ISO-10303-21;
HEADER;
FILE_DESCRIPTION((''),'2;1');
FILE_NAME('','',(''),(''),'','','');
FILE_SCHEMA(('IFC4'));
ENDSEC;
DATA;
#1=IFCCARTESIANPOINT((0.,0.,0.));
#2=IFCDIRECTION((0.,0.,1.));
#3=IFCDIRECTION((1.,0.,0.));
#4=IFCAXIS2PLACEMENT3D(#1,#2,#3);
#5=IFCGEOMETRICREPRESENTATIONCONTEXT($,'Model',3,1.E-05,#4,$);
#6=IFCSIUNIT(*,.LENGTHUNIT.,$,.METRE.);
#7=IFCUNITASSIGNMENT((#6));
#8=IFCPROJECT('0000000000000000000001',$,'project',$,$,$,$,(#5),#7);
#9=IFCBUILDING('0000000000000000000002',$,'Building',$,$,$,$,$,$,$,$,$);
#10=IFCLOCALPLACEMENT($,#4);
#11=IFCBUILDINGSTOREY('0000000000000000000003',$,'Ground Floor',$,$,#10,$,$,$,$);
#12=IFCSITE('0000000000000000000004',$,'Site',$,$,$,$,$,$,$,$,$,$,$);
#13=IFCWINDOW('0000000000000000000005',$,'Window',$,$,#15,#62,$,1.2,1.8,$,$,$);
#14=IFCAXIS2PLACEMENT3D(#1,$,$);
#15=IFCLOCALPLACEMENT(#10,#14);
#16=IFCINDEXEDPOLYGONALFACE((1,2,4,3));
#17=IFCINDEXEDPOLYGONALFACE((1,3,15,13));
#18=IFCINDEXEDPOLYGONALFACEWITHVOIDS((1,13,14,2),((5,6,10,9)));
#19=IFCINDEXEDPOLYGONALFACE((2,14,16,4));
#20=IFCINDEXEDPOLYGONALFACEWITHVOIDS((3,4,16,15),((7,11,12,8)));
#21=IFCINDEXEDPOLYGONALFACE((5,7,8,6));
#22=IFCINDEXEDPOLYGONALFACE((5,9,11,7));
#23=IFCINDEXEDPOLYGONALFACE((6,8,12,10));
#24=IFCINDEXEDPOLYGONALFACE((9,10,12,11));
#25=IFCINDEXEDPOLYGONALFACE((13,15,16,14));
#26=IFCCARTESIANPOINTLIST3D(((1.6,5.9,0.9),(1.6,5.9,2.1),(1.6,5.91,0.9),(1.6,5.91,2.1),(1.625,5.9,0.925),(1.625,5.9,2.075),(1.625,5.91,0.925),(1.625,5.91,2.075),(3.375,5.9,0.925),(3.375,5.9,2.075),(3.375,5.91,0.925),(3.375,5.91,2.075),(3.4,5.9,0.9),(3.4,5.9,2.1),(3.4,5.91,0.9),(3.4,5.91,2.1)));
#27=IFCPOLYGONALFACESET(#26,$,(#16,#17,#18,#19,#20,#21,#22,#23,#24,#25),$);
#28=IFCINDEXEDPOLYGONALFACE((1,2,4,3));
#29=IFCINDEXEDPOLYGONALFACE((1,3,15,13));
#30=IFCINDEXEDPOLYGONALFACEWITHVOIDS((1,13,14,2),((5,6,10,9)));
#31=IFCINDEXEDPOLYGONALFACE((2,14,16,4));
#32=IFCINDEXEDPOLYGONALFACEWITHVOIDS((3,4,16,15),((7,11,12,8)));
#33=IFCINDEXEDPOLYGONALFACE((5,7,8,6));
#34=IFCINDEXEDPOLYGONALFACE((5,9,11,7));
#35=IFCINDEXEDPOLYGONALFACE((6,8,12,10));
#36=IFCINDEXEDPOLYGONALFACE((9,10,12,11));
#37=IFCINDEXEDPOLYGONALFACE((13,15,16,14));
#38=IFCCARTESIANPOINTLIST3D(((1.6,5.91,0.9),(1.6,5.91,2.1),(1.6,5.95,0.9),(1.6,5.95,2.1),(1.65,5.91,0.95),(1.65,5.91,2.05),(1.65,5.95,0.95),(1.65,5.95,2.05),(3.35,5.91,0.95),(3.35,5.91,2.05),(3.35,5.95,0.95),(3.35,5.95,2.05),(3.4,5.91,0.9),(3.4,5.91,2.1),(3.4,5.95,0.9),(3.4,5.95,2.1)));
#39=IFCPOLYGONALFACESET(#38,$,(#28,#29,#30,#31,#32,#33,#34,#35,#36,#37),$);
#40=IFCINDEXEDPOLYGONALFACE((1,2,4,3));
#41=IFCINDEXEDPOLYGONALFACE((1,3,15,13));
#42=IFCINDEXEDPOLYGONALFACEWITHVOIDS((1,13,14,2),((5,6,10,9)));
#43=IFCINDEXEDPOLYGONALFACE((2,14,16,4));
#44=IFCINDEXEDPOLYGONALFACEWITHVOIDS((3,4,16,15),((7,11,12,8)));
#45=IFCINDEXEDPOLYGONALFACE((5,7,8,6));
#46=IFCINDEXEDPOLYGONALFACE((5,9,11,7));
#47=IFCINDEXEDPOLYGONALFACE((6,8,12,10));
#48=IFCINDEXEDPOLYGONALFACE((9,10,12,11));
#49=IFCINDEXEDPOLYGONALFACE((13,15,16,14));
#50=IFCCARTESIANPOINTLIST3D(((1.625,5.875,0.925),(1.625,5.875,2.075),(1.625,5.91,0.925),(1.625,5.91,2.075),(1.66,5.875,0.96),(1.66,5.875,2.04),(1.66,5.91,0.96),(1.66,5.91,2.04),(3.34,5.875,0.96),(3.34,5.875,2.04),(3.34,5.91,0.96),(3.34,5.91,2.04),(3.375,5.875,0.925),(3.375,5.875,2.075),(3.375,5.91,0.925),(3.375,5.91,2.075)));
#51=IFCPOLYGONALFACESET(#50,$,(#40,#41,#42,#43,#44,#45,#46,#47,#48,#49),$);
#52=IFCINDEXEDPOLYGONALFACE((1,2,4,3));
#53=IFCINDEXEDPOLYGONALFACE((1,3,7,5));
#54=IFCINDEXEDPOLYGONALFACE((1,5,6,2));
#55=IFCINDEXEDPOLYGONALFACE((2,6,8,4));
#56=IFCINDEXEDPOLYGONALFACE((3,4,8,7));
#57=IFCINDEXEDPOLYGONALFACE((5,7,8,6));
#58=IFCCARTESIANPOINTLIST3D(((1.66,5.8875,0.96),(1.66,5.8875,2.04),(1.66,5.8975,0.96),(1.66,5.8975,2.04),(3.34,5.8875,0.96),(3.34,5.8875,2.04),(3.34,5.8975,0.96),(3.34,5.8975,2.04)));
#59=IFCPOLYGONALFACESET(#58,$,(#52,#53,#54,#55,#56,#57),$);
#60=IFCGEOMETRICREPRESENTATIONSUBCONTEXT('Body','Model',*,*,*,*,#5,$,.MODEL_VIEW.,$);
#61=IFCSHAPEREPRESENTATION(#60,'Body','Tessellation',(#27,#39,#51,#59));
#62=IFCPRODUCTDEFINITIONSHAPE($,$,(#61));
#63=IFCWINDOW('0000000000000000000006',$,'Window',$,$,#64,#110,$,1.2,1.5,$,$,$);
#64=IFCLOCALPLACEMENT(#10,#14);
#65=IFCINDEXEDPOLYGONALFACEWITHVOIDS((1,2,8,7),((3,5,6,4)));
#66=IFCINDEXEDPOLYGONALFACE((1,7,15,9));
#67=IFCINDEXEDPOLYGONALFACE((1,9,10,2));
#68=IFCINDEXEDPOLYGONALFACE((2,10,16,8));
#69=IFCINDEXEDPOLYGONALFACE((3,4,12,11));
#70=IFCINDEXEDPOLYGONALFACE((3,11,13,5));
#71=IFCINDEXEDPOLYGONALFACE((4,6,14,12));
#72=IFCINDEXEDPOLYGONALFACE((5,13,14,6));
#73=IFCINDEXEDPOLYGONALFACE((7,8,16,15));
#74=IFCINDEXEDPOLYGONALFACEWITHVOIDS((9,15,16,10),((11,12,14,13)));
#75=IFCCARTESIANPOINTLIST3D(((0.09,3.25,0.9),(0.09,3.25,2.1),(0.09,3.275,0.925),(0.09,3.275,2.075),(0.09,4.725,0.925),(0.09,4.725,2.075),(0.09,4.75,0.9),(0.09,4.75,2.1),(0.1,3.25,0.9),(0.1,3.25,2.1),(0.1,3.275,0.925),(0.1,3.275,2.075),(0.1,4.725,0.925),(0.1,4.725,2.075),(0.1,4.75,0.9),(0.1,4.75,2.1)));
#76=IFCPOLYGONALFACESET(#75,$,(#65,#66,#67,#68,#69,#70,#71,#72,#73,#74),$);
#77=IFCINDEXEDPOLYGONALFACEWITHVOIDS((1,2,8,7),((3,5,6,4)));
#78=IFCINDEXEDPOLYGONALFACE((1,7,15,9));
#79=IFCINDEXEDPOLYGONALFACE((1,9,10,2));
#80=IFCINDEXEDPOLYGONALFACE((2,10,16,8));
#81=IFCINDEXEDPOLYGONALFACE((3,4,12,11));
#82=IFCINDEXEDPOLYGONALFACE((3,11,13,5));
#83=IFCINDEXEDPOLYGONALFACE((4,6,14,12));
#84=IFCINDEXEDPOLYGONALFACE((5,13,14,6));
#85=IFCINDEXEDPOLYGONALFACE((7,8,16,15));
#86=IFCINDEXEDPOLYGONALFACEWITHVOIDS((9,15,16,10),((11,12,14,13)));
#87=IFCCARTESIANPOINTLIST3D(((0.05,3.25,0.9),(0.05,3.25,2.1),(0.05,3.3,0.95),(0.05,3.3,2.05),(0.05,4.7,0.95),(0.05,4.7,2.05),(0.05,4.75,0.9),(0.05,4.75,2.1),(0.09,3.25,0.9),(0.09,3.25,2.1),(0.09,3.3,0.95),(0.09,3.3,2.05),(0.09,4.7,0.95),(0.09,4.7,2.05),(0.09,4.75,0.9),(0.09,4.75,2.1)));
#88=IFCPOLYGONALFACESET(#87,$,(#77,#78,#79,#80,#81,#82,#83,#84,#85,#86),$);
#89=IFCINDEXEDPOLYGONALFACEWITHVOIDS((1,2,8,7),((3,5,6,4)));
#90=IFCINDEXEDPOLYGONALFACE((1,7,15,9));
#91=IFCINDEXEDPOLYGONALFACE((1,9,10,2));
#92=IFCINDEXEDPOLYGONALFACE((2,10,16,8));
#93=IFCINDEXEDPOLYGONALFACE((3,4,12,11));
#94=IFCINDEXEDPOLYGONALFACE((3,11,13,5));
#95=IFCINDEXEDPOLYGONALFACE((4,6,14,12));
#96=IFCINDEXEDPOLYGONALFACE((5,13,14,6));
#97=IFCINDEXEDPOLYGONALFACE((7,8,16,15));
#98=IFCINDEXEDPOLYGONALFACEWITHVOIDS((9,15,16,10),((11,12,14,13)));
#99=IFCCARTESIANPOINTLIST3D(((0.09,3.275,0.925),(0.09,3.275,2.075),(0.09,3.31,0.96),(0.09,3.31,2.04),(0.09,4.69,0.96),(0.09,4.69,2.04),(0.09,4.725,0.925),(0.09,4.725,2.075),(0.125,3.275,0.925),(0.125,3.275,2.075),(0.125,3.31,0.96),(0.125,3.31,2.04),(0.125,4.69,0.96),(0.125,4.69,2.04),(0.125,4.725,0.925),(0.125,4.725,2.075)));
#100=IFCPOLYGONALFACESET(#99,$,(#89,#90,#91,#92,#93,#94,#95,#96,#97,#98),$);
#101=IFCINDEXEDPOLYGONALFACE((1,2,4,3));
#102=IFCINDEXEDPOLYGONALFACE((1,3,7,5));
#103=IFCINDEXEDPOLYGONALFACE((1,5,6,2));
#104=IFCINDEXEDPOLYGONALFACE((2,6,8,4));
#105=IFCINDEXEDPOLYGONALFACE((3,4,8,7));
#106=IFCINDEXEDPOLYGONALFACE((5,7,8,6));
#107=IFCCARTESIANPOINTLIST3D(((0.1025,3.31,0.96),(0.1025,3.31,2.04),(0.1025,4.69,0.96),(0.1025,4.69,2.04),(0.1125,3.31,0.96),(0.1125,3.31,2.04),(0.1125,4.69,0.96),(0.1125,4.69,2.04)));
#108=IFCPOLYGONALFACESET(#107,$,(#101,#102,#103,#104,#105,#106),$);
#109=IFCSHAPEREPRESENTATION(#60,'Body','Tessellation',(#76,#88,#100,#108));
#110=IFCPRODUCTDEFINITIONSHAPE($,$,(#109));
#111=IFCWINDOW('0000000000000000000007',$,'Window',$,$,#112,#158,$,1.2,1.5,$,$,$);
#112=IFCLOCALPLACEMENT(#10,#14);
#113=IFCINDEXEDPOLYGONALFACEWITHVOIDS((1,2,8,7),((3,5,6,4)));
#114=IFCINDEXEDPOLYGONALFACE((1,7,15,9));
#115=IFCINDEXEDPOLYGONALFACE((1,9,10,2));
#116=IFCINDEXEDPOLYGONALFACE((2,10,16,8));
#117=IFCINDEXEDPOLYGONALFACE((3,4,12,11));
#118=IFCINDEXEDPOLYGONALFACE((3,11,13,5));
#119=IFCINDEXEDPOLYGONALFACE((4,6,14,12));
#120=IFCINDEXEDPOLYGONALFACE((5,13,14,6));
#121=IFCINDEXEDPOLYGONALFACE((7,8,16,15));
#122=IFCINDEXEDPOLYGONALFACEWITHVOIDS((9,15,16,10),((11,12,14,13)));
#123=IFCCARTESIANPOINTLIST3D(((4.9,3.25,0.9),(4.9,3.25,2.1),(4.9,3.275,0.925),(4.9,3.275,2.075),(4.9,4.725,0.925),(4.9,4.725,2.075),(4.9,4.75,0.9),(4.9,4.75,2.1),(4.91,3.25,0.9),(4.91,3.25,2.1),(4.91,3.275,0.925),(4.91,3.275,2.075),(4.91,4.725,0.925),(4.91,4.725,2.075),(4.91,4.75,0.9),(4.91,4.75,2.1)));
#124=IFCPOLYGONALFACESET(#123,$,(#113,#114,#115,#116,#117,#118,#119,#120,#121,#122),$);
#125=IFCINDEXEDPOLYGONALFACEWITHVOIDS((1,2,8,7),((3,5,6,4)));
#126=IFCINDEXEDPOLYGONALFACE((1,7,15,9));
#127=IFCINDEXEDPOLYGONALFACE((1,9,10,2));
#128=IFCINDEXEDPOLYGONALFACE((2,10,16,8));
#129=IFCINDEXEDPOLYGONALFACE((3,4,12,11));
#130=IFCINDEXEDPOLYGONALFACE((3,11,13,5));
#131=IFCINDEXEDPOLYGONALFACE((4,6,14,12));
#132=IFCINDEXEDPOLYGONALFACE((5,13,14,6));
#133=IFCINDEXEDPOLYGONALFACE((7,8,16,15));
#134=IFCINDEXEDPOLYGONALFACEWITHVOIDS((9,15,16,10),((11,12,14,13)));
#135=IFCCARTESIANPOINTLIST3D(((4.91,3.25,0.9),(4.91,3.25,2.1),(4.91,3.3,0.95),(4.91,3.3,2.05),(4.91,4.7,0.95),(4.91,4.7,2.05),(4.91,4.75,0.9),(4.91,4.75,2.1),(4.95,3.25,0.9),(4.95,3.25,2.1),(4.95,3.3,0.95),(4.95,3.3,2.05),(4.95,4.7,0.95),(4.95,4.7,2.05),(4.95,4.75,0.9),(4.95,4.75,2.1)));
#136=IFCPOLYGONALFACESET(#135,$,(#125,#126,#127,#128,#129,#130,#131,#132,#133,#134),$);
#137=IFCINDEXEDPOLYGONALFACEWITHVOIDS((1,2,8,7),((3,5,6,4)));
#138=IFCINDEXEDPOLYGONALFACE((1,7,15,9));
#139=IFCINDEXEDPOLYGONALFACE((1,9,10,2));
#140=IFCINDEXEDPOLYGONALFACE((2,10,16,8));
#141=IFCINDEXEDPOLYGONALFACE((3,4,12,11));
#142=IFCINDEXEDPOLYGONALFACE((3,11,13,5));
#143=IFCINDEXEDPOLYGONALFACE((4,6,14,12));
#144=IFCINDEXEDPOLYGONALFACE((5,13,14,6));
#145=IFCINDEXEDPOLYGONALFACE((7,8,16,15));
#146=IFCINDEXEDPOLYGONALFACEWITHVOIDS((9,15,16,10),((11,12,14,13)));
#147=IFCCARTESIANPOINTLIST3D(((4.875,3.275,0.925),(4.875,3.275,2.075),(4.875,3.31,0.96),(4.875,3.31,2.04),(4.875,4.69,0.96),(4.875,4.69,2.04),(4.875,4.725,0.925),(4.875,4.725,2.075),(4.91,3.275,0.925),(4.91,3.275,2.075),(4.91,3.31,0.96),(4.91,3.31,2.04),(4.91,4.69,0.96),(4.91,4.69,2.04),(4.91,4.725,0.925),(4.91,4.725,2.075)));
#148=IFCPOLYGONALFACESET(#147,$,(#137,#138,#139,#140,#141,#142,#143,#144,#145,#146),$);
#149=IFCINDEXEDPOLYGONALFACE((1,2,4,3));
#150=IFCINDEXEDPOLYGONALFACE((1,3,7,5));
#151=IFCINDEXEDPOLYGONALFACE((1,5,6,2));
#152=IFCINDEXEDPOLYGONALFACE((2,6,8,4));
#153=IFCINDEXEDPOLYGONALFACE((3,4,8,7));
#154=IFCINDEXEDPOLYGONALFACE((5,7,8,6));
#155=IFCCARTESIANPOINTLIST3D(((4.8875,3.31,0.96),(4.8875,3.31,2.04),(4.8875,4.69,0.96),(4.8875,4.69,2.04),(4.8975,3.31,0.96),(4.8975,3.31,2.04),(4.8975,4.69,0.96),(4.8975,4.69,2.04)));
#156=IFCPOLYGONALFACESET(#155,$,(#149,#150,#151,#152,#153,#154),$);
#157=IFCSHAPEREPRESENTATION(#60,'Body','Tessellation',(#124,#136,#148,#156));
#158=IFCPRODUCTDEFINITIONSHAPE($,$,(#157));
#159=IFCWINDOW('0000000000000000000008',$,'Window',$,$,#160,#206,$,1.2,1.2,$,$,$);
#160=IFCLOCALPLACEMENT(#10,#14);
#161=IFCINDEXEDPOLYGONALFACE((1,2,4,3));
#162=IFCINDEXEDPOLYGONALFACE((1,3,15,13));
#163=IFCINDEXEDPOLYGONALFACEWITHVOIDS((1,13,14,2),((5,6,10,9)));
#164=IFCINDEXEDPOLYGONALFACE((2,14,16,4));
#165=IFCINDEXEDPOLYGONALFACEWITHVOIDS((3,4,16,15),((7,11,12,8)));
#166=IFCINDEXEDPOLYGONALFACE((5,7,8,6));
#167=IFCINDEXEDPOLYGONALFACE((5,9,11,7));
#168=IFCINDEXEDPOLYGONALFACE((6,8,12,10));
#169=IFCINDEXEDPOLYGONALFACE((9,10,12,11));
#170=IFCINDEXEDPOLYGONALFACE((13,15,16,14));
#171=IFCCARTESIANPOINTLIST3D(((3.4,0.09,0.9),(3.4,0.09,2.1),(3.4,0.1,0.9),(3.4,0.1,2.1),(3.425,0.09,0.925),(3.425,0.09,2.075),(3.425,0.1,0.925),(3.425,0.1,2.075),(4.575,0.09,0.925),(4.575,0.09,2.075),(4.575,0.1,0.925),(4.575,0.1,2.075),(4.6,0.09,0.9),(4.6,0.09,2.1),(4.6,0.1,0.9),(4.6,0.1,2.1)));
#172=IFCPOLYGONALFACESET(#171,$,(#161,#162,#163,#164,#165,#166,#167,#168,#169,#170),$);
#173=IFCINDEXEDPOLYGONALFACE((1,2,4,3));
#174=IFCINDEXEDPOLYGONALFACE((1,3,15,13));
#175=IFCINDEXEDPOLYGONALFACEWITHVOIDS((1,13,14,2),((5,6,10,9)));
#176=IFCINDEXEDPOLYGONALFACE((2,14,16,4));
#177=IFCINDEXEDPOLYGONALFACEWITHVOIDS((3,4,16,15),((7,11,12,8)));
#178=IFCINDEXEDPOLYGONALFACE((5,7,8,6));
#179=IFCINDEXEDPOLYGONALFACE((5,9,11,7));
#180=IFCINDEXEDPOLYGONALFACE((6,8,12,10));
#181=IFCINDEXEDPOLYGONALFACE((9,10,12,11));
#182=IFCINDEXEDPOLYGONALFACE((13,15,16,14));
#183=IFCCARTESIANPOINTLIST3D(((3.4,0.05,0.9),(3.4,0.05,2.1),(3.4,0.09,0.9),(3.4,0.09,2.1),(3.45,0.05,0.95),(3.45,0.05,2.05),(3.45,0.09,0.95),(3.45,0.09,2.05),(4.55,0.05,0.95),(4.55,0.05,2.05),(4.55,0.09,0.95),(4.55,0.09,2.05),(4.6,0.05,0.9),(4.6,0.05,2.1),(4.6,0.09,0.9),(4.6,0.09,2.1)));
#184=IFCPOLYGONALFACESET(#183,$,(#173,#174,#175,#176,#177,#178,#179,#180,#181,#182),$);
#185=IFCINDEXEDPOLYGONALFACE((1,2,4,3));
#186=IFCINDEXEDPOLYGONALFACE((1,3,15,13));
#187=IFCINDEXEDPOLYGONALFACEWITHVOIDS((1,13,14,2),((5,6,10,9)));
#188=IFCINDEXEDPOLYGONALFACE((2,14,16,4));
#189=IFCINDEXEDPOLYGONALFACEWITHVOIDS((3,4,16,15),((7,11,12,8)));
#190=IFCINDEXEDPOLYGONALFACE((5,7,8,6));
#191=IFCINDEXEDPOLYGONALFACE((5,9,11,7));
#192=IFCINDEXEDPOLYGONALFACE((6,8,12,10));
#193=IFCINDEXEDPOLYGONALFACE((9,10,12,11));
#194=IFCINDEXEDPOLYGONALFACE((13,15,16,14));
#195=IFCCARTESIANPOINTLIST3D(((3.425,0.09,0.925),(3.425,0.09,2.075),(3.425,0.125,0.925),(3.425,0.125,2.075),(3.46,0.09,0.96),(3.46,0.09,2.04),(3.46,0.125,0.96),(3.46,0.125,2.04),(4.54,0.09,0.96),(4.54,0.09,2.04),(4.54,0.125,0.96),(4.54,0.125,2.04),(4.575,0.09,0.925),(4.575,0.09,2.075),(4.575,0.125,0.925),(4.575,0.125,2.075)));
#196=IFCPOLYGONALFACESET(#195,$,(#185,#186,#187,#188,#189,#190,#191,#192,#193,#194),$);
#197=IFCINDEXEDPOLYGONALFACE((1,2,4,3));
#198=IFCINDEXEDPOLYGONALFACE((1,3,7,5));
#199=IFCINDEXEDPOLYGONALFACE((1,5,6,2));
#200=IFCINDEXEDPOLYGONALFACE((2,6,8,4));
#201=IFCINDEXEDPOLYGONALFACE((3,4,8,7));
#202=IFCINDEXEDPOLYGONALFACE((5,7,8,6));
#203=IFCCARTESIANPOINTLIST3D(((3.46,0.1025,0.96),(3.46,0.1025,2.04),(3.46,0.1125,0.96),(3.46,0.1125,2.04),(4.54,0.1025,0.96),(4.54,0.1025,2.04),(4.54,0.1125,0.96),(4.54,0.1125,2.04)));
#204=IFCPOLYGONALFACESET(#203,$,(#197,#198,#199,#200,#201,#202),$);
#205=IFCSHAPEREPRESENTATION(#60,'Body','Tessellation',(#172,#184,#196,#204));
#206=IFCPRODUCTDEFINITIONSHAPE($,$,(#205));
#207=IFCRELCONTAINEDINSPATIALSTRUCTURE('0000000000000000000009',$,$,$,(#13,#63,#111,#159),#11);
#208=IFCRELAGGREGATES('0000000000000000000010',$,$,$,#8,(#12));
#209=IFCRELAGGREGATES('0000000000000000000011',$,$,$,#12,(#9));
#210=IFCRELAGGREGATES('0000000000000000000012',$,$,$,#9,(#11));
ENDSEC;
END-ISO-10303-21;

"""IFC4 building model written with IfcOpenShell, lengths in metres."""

from ifc_helpers import new_model, si_unit, frame, origin_with_axes, place, context, subcontext, project, spatial, line, indexed_curve, outline, extrude, element, save


model = new_model("IFC4")

# Units and contexts
model_context = context("Model", 3, precision=1e-05, world=origin_with_axes())
body_context = subcontext(model_context, "Body", "Model", "MODEL_VIEW")
ifc_project = project(units=[si_unit("LENGTHUNIT", "METRE")], contexts=[model_context])

# Site, building, storey
site = spatial("IfcSite", under=ifc_project, Name="Site")
building = spatial("IfcBuilding", under=site, Name="Building")
storey_placement = place(None, origin_with_axes())
storey = spatial("IfcBuildingStorey", under=building, at=storey_placement, Name="Ground Floor")

# Windows
window_1_placement = place(storey_placement, frame((3.4, 6.0, 0.9), z_axis=(0.0, 0.0, 1.0), x_axis=(-1.0, 0.0, 0.0)))
element("IfcWindow", 1, at=window_1_placement, inside=storey, Name="Window", OverallHeight=1.2, OverallWidth=1.8, context=body_context, shape_type="SweptSolid", body=[
    extrude(outline(indexed_curve([(0.0, 0.0), (1.8, 0.0), (1.8, 1.2), (0.0, 1.2)], segments=[line(1, 2, 3, 4, 1)]), holes=[indexed_curve([(0.025, 0.025), (1.775, 0.025), (1.775, 1.175), (0.025, 1.175)], segments=[line(1, 2, 3, 4, 1)])]), frame((0.0, 0.09, 0.0), z_axis=(0.0, -1.0, 0.0), x_axis=(1.0, 0.0, 0.0)), (0.0, 0.0, -1.0), 0.01),
    extrude(outline(indexed_curve([(0.0, 0.0), (1.8, 0.0), (1.8, 1.2), (0.0, 1.2)], segments=[line(1, 2, 3, 4, 1)]), holes=[indexed_curve([(0.05, 0.05), (1.75, 0.05), (1.75, 1.15), (0.05, 1.15)], segments=[line(1, 2, 3, 4, 1)])]), frame((0.0, 0.05, 0.0), z_axis=(0.0, -1.0, 0.0), x_axis=(1.0, 0.0, 0.0)), (0.0, 0.0, -1.0), 0.04),
    extrude(outline(indexed_curve([(0.0, 0.0), (1.75, 0.0), (1.75, 1.15), (0.0, 1.15)], segments=[line(1, 2, 3, 4, 1)]), holes=[indexed_curve([(0.035, 0.035), (1.715, 0.035), (1.715, 1.115), (0.035, 1.115)], segments=[line(1, 2, 3, 4, 1)])]), frame((0.025, 0.09, 0.025), z_axis=(0.0, -1.0, 0.0), x_axis=(1.0, 0.0, 0.0)), (0.0, 0.0, -1.0), 0.035),
    extrude(outline(indexed_curve([(0.035, 0.035), (1.715, 0.035), (1.715, 1.115), (0.035, 1.115)], segments=[line(1, 2, 3, 4, 1)])), frame((0.025, 0.1025, 0.025), z_axis=(0.0, -1.0, 0.0), x_axis=(1.0, 0.0, 0.0)), (0.0, 0.0, -1.0), 0.01),
])
for number, where, z_axis, x_axis, name in (
    (2, (0.0, 4.75, 0.9), (0.0, 0.0, 1.0), (0.0, -1.0, 0.0), "Window"),
    (3, (5.0, 3.25, 0.9), (0.0, 0.0, 1.0), (0.0, 1.0, 0.0), "Window"),
):
    element("IfcWindow", number, at=place(storey_placement, frame(where, z_axis=z_axis, x_axis=x_axis)), inside=storey, Name=name, OverallHeight=1.2, OverallWidth=1.5, context=body_context, shape_type="SweptSolid", body=[
        extrude(outline(indexed_curve([(0.0, 0.0), (1.5, 0.0), (1.5, 1.2), (0.0, 1.2)], segments=[line(1, 2, 3, 4, 1)]), holes=[indexed_curve([(0.025, 0.025), (1.475, 0.025), (1.475, 1.175), (0.025, 1.175)], segments=[line(1, 2, 3, 4, 1)])]), frame((0.0, 0.09, 0.0), z_axis=(0.0, -1.0, 0.0), x_axis=(1.0, 0.0, 0.0)), (0.0, 0.0, -1.0), 0.01),
        extrude(outline(indexed_curve([(0.0, 0.0), (1.5, 0.0), (1.5, 1.2), (0.0, 1.2)], segments=[line(1, 2, 3, 4, 1)]), holes=[indexed_curve([(0.05, 0.05), (1.45, 0.05), (1.45, 1.15), (0.05, 1.15)], segments=[line(1, 2, 3, 4, 1)])]), frame((0.0, 0.05, 0.0), z_axis=(0.0, -1.0, 0.0), x_axis=(1.0, 0.0, 0.0)), (0.0, 0.0, -1.0), 0.04),
        extrude(outline(indexed_curve([(0.0, 0.0), (1.45, 0.0), (1.45, 1.15), (0.0, 1.15)], segments=[line(1, 2, 3, 4, 1)]), holes=[indexed_curve([(0.035, 0.035), (1.415, 0.035), (1.415, 1.115), (0.035, 1.115)], segments=[line(1, 2, 3, 4, 1)])]), frame((0.025, 0.09, 0.025), z_axis=(0.0, -1.0, 0.0), x_axis=(1.0, 0.0, 0.0)), (0.0, 0.0, -1.0), 0.035),
        extrude(outline(indexed_curve([(0.035, 0.035), (1.415, 0.035), (1.415, 1.115), (0.035, 1.115)], segments=[line(1, 2, 3, 4, 1)])), frame((0.025, 0.1025, 0.025), z_axis=(0.0, -1.0, 0.0), x_axis=(1.0, 0.0, 0.0)), (0.0, 0.0, -1.0), 0.01),
    ])
window_2_placement = place(storey_placement, frame((3.4, 0.0, 0.9), z_axis=(0.0, 0.0, 1.0), x_axis=(1.0, 0.0, 0.0)))
element("IfcWindow", 4, at=window_2_placement, inside=storey, Name="Window", OverallHeight=1.2, OverallWidth=1.2, context=body_context, shape_type="SweptSolid", body=[
    extrude(outline(indexed_curve([(0.0, 0.0), (1.2, 0.0), (1.2, 1.2), (0.0, 1.2)], segments=[line(1, 2, 3, 4, 1)]), holes=[indexed_curve([(0.025, 0.025), (1.175, 0.025), (1.175, 1.175), (0.025, 1.175)], segments=[line(1, 2, 3, 4, 1)])]), frame((0.0, 0.09, 0.0), z_axis=(0.0, -1.0, 0.0), x_axis=(1.0, 0.0, 0.0)), (0.0, 0.0, -1.0), 0.01),
    extrude(outline(indexed_curve([(0.0, 0.0), (1.2, 0.0), (1.2, 1.2), (0.0, 1.2)], segments=[line(1, 2, 3, 4, 1)]), holes=[indexed_curve([(0.05, 0.05), (1.15, 0.05), (1.15, 1.15), (0.05, 1.15)], segments=[line(1, 2, 3, 4, 1)])]), frame((0.0, 0.05, 0.0), z_axis=(0.0, -1.0, 0.0), x_axis=(1.0, 0.0, 0.0)), (0.0, 0.0, -1.0), 0.04),
    extrude(outline(indexed_curve([(0.0, 0.0), (1.15, 0.0), (1.15, 1.15), (0.0, 1.15)], segments=[line(1, 2, 3, 4, 1)]), holes=[indexed_curve([(0.035, 0.035), (1.115, 0.035), (1.115, 1.115), (0.035, 1.115)], segments=[line(1, 2, 3, 4, 1)])]), frame((0.025, 0.09, 0.025), z_axis=(0.0, -1.0, 0.0), x_axis=(1.0, 0.0, 0.0)), (0.0, 0.0, -1.0), 0.035),
    extrude(outline(indexed_curve([(0.035, 0.035), (1.115, 0.035), (1.115, 1.115), (0.035, 1.115)], segments=[line(1, 2, 3, 4, 1)])), frame((0.025, 0.1025, 0.025), z_axis=(0.0, -1.0, 0.0), x_axis=(1.0, 0.0, 0.0)), (0.0, 0.0, -1.0), 0.01),
])

save(model, "model.ifc")
